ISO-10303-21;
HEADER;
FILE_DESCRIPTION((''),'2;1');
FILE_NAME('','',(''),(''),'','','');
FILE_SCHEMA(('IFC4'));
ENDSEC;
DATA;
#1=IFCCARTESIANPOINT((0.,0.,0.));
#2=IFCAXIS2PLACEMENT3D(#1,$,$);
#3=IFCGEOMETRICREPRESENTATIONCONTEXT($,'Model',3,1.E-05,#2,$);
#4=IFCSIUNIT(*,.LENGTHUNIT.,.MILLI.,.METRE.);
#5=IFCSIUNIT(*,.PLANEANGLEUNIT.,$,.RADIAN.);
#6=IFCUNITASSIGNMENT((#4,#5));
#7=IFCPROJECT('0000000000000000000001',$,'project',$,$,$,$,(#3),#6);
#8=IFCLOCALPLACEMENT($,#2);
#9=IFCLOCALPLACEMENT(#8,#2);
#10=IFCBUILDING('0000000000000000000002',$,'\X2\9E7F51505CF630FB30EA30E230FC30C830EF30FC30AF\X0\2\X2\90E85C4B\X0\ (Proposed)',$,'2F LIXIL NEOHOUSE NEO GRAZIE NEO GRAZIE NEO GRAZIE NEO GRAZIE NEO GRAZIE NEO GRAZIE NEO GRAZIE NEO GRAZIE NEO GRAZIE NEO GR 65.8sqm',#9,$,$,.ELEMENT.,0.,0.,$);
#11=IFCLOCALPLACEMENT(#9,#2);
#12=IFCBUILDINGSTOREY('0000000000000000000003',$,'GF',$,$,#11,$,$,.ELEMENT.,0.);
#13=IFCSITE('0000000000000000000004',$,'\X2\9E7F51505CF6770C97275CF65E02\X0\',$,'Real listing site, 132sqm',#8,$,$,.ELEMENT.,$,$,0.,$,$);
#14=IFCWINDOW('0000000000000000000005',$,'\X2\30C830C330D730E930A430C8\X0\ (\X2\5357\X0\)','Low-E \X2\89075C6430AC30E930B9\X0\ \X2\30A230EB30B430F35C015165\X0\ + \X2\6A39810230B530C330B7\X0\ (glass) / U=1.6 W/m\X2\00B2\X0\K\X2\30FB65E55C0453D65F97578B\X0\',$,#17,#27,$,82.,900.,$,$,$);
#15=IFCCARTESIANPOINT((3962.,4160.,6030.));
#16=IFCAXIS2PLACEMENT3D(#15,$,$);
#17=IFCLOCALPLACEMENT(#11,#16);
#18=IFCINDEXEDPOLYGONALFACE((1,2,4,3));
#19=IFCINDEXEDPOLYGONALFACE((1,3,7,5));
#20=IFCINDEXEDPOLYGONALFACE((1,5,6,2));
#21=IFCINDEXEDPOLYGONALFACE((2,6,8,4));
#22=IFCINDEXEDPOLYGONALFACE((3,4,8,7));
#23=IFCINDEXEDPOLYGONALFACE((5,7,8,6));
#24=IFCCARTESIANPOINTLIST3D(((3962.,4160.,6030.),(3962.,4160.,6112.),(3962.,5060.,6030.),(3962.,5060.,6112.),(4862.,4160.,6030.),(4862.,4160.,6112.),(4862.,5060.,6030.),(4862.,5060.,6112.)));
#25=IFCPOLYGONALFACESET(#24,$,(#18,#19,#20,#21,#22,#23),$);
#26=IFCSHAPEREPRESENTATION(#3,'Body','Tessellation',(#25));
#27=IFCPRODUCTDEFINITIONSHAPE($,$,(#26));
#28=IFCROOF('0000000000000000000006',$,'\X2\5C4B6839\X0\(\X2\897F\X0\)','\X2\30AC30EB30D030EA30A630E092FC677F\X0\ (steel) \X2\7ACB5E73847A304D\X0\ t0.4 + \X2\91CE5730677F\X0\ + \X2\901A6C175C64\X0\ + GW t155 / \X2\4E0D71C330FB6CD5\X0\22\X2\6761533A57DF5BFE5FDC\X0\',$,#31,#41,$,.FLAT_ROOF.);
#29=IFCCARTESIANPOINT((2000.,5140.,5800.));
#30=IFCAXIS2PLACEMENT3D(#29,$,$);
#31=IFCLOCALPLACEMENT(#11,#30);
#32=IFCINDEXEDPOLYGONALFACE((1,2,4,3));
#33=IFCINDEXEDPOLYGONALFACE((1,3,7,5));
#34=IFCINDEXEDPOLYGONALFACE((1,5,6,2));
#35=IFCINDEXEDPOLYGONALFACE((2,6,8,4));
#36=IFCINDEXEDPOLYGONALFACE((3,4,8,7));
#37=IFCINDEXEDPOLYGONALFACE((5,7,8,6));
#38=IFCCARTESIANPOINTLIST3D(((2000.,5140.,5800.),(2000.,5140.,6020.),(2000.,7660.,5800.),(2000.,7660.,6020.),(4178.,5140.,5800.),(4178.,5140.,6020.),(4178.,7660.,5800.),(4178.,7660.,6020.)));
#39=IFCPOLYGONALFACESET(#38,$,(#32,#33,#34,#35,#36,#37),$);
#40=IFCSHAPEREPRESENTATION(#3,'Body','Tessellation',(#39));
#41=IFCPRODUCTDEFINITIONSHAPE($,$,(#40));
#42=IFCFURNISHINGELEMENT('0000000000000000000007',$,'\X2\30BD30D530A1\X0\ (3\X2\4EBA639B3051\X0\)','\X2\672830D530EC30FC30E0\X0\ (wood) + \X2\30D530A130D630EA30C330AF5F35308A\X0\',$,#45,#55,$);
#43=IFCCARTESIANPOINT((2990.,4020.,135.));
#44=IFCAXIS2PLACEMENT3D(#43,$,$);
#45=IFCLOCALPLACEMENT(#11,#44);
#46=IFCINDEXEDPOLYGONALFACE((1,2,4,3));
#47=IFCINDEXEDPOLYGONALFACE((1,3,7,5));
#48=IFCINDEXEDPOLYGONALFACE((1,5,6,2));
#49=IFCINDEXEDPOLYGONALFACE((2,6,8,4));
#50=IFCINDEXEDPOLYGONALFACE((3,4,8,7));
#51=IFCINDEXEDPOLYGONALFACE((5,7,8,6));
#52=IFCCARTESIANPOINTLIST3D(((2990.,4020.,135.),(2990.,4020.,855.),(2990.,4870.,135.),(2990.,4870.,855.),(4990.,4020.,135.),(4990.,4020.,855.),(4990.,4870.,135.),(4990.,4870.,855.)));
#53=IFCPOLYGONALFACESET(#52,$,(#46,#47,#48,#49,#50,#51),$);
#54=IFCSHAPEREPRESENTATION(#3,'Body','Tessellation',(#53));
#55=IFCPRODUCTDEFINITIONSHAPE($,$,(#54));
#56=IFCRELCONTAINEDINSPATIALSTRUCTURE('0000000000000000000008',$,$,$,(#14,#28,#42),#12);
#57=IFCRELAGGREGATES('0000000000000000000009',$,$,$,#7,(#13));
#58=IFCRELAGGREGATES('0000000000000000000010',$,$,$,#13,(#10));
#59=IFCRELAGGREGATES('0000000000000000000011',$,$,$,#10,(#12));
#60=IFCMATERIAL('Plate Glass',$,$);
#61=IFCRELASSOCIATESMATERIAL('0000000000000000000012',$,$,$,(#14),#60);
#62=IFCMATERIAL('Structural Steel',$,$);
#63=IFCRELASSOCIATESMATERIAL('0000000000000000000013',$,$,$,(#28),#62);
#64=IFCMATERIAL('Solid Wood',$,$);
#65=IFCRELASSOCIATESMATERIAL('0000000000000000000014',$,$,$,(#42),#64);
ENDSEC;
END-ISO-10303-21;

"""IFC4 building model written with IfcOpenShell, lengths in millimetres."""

from ifc_helpers import new_model, si_unit, frame, frame_2d, origin, place, context, project, spatial, rectangle, extrude, material, element, save


model = new_model("IFC4")

# Units and contexts
model_context = context("Model", 3, precision=1e-05, world=origin())
ifc_project = project(units=[si_unit("LENGTHUNIT", "METRE", prefix="MILLI"), si_unit("PLANEANGLEUNIT", "RADIAN")], contexts=[model_context])

# Site, building, storey
site_placement = place(None, origin())
site = spatial("IfcSite", under=ifc_project, at=site_placement, Name="鹿児島県霧島市", ObjectType="Real listing site, 132sqm", CompositionType="ELEMENT", RefElevation=0.0)
building_placement = place(site_placement, origin())
building = spatial("IfcBuilding", under=site, at=building_placement, Name="鹿児島・リモートワーク2部屋 (Proposed)", ObjectType="2F LIXIL NEOHOUSE NEO GRAZIE NEO GRAZIE NEO GRAZIE NEO GRAZIE NEO GRAZIE NEO GRAZIE NEO GRAZIE NEO GRAZIE NEO GRAZIE NEO GR 65.8sqm", CompositionType="ELEMENT", ElevationOfRefHeight=0.0, ElevationOfTerrain=0.0)
storey_placement = place(building_placement, origin())
storey = spatial("IfcBuildingStorey", under=building, at=storey_placement, Name="GF", CompositionType="ELEMENT", Elevation=0.0)

# Shared definitions
ifc_material_1 = material(Name="Solid Wood")

# Shared definitions
ifc_material_2 = material(Name="Plate Glass")

# Window
window_1_placement = place(storey_placement, frame((3962.0, 4160.0, 6030.0)))
element("IfcWindow", 1, at=window_1_placement, inside=storey, material=ifc_material_2, Name="トップライト (南)", Description="Low-E 複層ガラス アルゴン封入 + 樹脂サッシ (glass) / U=1.6 W/m²K・日射取得型", OverallHeight=82.0, OverallWidth=900.0, context=model_context, shape_type="SweptSolid", body=[
    extrude(rectangle(XDim=900.0, YDim=900.0, at=frame_2d((450.0, 450.0))), frame((3962.0, 4160.0, 6030.0)), (0.0, 0.0, 1.0), 82.0),
])

# Roof
ifc_material_3 = material(Name="Structural Steel")
for number, where, name in (
    (2, (2000.0, 5140.0, 5800.0), "屋根(西)"),
):
    element("IfcRoof", number, at=place(storey_placement, frame(where)), inside=storey, material=ifc_material_3, Name=name, Description="ガルバリウム鋼板 (steel) 立平葺き t0.4 + 野地板 + 通気層 + GW t155 / 不燃・法22条区域対応", PredefinedType="FLAT_ROOF", context=model_context, shape_type="SweptSolid", body=[
        extrude(rectangle(XDim=2178.0, YDim=2520.0, at=frame_2d((1089.0, 1260.0))), frame((2000.0, 5140.0, 5800.0)), (0.0, 0.0, 1.0), 220.0),
    ])

# Furnishing element
furnishing_placement = place(storey_placement, frame((2990.0, 4020.0, 135.0)))
element("IfcFurnishingElement", 3, at=furnishing_placement, inside=storey, material=ifc_material_1, Name="ソファ (3人掛け)", Description="木フレーム (wood) + ファブリック張り", context=model_context, shape_type="SweptSolid", body=[
    extrude(rectangle(XDim=2000.0, YDim=850.0, at=frame_2d((1000.0, 425.0))), frame((2990.0, 4020.0, 135.0)), (0.0, 0.0, 1.0), 720.0),
])

save(model, "model.ifc")
